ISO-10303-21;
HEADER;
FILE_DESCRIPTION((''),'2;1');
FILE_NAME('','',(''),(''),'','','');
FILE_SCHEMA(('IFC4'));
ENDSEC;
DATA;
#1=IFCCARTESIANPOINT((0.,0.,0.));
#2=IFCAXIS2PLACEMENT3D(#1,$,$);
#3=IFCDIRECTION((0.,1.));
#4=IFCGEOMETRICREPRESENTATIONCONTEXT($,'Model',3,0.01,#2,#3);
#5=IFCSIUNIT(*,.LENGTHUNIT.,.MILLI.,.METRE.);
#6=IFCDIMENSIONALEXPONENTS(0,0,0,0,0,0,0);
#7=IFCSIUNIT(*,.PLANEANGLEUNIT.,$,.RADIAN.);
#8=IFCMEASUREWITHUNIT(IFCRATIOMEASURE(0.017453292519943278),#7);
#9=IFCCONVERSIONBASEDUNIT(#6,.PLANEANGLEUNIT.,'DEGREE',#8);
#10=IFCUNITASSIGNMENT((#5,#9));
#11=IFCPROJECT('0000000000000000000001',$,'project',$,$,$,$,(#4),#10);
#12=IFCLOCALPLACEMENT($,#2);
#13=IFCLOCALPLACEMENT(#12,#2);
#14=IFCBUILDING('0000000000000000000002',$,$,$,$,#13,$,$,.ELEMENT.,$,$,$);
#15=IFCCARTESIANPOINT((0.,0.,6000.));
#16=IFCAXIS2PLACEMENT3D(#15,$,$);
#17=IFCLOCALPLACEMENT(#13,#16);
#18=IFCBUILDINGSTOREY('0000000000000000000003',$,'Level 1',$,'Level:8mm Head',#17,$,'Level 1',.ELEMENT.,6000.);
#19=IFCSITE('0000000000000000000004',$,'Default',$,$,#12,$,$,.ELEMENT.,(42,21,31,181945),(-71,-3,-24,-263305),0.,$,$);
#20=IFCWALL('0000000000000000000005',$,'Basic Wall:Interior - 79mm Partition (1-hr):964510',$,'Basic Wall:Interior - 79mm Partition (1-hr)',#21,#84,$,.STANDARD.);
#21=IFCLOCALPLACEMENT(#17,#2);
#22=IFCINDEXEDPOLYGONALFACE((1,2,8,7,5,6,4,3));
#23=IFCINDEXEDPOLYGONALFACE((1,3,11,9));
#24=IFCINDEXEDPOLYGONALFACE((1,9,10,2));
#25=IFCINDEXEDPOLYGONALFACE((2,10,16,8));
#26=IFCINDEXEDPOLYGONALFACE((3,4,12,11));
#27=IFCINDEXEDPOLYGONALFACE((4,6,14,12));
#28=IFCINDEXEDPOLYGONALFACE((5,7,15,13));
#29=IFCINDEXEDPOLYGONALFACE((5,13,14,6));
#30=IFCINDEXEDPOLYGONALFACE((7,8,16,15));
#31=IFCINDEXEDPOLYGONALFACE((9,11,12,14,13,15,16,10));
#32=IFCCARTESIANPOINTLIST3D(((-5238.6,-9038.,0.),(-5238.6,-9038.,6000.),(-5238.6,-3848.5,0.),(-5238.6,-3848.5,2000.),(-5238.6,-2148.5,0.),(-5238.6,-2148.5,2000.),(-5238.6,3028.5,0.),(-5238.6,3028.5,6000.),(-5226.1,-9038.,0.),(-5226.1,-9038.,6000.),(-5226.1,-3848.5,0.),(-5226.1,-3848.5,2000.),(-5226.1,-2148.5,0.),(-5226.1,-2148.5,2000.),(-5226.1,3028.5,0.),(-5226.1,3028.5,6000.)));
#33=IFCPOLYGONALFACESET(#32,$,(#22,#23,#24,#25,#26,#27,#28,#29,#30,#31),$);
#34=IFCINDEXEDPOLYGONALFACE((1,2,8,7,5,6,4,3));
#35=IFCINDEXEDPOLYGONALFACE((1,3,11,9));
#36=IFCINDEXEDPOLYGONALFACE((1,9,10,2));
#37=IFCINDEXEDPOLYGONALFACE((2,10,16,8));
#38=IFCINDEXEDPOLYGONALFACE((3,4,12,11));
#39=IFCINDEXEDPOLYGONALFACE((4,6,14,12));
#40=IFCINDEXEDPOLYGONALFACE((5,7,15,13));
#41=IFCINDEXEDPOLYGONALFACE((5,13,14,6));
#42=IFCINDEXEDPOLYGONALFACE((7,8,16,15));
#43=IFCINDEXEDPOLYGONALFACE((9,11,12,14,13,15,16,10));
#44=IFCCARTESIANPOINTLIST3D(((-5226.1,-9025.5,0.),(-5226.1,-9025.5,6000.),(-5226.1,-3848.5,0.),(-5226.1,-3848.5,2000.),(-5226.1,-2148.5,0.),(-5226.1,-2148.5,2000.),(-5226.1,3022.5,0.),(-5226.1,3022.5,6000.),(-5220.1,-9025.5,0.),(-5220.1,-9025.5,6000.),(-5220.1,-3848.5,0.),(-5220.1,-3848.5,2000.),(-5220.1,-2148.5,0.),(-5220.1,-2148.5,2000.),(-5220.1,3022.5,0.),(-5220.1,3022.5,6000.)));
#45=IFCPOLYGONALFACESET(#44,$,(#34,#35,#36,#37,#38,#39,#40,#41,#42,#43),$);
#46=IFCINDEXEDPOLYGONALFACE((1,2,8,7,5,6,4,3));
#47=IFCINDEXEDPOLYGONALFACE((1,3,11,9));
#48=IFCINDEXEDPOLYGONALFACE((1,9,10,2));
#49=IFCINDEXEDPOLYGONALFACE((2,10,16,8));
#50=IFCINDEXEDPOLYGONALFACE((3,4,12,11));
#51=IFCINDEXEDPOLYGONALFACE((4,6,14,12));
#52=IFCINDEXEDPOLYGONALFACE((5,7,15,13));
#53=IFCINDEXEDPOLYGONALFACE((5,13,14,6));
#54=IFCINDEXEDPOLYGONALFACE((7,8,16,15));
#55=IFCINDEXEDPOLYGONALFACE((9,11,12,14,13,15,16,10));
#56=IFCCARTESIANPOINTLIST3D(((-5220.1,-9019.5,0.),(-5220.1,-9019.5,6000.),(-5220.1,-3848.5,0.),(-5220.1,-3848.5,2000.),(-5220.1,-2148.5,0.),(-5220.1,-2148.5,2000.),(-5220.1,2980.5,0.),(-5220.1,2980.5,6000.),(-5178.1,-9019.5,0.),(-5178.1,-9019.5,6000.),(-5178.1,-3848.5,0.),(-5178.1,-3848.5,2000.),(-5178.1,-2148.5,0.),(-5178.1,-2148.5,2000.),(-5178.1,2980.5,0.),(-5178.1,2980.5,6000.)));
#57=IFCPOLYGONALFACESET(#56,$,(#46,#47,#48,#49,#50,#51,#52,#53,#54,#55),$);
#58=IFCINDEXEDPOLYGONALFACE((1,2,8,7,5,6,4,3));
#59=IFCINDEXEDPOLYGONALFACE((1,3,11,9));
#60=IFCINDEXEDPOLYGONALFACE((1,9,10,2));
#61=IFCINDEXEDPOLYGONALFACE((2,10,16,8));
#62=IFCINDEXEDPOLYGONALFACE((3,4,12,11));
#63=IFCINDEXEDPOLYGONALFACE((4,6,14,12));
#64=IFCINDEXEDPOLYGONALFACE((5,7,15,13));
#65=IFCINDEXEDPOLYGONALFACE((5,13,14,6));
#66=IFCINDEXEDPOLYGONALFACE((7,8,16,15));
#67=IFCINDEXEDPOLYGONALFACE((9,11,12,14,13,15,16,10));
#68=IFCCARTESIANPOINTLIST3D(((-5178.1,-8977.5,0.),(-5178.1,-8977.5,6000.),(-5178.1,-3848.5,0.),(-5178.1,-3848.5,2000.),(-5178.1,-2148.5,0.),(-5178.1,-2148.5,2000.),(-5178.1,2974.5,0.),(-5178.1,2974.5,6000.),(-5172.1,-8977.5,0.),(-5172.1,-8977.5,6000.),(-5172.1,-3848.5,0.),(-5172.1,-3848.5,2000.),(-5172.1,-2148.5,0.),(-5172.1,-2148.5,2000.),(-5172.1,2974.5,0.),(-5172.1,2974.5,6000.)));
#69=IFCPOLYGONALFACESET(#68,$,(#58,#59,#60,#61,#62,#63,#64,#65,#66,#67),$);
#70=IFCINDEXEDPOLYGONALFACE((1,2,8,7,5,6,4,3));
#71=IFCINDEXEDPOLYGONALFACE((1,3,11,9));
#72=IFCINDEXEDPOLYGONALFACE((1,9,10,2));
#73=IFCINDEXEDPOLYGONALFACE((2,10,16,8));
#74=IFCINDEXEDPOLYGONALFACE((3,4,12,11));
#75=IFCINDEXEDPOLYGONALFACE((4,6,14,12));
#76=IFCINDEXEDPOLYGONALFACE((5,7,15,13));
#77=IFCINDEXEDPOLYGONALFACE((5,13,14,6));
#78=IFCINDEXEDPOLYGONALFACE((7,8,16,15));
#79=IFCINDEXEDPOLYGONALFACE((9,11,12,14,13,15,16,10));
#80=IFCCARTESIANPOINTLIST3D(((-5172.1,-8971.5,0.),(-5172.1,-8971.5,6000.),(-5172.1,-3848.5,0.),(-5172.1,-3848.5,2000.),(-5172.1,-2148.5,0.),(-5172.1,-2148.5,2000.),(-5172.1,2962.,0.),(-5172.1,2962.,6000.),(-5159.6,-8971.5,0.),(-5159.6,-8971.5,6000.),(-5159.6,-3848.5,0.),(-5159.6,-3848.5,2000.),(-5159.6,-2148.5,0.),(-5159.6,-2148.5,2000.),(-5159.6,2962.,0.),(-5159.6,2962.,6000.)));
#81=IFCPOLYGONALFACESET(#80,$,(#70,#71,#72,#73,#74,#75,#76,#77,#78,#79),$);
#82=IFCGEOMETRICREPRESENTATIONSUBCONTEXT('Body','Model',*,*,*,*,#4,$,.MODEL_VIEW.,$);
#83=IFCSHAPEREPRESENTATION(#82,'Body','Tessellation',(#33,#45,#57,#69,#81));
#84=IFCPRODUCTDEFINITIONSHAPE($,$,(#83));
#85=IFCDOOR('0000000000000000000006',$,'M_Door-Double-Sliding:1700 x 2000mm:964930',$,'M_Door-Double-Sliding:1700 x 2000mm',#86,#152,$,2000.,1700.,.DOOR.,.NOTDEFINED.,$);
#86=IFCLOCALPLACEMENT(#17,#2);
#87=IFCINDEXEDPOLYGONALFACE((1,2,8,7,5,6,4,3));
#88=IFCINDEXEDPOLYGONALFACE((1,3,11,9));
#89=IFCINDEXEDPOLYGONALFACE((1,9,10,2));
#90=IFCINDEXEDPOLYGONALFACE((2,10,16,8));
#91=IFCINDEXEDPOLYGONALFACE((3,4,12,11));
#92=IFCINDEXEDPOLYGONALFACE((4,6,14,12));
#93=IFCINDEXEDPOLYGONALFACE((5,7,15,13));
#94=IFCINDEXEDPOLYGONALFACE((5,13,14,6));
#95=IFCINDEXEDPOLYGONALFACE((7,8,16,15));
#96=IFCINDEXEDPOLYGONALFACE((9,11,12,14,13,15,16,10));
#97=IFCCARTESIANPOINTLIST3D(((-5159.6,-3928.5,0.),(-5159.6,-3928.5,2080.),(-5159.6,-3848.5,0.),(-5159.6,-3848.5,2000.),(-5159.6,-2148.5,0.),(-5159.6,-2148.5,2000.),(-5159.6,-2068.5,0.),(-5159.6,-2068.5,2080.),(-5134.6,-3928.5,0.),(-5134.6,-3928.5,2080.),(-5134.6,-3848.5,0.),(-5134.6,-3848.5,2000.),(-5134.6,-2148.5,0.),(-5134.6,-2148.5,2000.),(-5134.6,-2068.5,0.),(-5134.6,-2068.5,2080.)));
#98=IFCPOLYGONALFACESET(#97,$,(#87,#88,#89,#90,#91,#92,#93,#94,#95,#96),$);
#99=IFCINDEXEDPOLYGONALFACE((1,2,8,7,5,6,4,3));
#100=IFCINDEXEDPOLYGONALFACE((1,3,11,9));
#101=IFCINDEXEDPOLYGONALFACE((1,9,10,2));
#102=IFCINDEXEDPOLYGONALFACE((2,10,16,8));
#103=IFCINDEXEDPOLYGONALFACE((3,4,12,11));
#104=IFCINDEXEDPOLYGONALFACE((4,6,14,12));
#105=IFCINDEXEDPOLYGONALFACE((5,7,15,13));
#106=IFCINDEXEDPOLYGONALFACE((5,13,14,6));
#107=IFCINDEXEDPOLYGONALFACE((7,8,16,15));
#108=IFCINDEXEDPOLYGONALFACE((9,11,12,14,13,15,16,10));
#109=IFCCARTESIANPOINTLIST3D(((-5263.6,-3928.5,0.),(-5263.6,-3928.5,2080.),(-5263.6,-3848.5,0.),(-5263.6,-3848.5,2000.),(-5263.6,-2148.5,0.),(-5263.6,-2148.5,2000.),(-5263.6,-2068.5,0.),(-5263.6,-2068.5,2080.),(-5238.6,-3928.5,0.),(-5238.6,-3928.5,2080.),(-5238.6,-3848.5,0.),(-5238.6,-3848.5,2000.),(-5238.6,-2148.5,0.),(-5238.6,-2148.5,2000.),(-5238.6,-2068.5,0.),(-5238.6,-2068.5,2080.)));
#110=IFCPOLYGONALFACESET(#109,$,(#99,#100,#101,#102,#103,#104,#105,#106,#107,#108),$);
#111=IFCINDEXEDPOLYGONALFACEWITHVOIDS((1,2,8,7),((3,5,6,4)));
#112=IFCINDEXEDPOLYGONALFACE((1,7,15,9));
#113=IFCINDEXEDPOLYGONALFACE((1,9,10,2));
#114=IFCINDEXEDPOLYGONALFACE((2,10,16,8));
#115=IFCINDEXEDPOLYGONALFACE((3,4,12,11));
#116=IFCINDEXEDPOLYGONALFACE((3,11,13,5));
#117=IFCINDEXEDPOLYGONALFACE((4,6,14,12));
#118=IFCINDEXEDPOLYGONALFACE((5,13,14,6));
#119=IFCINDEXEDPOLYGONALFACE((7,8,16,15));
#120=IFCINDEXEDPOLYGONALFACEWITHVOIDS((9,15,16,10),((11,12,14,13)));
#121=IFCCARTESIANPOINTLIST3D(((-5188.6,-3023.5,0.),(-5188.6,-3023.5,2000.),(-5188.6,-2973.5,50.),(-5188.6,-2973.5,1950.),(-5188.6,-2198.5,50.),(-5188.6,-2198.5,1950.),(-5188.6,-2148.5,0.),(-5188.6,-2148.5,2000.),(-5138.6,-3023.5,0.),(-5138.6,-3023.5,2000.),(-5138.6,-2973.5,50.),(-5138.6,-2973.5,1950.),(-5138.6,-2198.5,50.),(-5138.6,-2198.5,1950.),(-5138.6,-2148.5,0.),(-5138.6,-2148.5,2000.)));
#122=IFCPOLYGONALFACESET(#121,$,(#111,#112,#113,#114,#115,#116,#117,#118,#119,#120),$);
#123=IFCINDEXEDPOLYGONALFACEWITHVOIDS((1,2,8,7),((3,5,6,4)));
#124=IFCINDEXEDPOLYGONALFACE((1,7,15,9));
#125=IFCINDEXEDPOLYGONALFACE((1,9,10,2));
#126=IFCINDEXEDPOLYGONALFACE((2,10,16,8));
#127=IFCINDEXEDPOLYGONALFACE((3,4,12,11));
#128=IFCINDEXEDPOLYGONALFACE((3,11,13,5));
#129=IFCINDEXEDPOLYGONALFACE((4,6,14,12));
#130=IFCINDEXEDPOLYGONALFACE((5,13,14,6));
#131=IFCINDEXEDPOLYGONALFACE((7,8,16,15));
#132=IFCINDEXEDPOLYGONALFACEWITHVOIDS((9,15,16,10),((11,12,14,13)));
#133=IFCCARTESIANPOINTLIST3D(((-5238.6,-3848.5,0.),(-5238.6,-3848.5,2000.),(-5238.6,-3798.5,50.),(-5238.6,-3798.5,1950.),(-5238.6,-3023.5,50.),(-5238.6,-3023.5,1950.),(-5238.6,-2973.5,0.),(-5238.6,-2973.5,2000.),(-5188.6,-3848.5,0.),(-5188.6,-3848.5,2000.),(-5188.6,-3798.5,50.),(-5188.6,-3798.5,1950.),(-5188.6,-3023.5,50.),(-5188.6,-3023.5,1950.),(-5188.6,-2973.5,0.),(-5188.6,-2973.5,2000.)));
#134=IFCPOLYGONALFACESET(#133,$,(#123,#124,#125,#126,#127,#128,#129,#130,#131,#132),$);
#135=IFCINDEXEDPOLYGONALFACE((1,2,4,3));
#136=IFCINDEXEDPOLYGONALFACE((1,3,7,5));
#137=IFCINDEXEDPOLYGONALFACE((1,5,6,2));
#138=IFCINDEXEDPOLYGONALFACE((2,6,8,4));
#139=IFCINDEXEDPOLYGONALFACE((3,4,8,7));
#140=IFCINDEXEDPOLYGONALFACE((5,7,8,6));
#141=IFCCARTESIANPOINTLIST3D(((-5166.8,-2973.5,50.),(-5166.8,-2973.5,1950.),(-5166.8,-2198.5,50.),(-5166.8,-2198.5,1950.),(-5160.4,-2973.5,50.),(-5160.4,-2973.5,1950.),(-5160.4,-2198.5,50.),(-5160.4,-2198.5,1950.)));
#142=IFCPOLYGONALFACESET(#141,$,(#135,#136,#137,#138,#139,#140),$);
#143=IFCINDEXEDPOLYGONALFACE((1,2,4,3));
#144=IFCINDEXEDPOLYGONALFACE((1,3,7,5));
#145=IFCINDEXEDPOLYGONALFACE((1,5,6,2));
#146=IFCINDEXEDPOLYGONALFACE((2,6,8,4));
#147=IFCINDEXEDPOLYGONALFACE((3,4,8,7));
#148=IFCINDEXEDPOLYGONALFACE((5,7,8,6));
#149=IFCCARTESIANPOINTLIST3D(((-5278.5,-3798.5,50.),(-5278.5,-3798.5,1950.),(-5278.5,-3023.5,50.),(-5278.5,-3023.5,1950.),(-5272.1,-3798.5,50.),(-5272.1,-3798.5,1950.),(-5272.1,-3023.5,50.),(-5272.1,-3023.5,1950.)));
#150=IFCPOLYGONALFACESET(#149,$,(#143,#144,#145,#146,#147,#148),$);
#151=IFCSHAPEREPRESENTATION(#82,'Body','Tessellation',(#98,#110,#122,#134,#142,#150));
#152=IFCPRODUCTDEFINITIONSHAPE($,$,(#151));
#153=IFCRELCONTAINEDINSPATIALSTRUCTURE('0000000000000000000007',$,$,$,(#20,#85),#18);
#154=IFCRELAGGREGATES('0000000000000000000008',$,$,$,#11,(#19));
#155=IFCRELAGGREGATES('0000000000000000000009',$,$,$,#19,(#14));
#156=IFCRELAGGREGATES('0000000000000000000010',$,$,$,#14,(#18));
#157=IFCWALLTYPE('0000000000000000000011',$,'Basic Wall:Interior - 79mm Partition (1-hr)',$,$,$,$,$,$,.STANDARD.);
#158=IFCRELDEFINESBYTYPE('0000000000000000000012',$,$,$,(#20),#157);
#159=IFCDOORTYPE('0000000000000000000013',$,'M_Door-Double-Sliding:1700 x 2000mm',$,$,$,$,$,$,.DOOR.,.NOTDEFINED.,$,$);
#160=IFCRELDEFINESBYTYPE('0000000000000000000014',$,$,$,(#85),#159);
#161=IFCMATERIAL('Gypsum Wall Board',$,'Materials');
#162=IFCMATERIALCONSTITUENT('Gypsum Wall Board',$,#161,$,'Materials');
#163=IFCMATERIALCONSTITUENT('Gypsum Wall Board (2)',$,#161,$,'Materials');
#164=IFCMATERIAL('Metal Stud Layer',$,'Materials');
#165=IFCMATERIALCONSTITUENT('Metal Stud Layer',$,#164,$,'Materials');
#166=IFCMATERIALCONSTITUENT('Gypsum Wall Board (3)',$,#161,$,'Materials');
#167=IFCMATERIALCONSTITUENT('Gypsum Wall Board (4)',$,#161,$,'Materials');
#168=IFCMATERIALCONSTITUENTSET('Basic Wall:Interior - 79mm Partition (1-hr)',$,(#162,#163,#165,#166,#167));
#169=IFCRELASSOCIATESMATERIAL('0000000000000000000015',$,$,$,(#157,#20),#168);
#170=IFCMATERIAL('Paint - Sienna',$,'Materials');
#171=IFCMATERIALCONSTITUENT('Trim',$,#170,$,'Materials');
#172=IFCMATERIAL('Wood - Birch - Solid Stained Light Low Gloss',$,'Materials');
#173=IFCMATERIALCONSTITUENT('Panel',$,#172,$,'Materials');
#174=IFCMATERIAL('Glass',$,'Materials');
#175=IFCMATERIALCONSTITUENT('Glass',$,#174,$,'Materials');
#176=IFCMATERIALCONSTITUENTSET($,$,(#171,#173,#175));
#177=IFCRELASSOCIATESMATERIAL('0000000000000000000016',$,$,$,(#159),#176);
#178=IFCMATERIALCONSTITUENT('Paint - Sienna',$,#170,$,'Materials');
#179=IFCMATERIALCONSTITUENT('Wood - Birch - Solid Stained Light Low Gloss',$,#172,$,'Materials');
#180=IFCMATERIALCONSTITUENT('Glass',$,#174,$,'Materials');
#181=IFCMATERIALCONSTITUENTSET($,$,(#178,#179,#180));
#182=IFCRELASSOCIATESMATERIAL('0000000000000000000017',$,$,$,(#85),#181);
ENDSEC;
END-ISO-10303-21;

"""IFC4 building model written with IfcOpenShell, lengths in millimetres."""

from ifc_helpers import new_model, entity, si_unit, converted_unit, direction, frame, origin, place, context, subcontext, project, spatial, indexed_curve, outline, extrude, source, transform, mapped, material, constituent, constituent_set, type_object, type_shapes, element, fill, save


model = new_model("IFC4")

# Units and contexts
model_context = context("Model", 3, precision=0.01, world=origin(), true_north=direction((0.0, 1.0)))
body_context = subcontext(model_context, "Body", "Model", "MODEL_VIEW")
ifc_project = project(units=[si_unit("LENGTHUNIT", "METRE", prefix="MILLI"), converted_unit("PLANEANGLEUNIT", "DEGREE", entity("IfcRatioMeasure", 0.017453292519943278), si_unit("PLANEANGLEUNIT", "RADIAN"), dimensions=[0, 0, 0, 0, 0, 0, 0])], contexts=[model_context])

# Site, building, storey
site_placement = place(None, origin())
site = spatial("IfcSite", under=ifc_project, at=site_placement, Name="Default", CompositionType="ELEMENT", RefLatitude=(42, 21, 31, 181945), RefLongitude=(-71, -3, -24, -263305), RefElevation=0.0)
building_placement = place(site_placement, origin())
building = spatial("IfcBuilding", under=site, at=building_placement, CompositionType="ELEMENT")
storey_placement = place(building_placement, frame((0.0, 0.0, 6000.0)))
storey = spatial("IfcBuildingStorey", under=building, at=storey_placement, Name="Level 1", ObjectType="Level:8mm Head", LongName="Level 1", CompositionType="ELEMENT", Elevation=6000.0)

# Shared definitions
ifc_material_1 = material(Name="Gypsum Wall Board", Category="Materials")
ifc_constituent_1 = constituent(ifc_material_1, Name="Gypsum Wall Board", Category="Materials")
ifc_constituent_2 = constituent(ifc_material_1, Name="Gypsum Wall Board (2)", Category="Materials")
ifc_material_2 = material(Name="Metal Stud Layer", Category="Materials")
ifc_constituent_3 = constituent(ifc_material_2, Name="Metal Stud Layer", Category="Materials")
ifc_constituent_4 = constituent(ifc_material_1, Name="Gypsum Wall Board (3)", Category="Materials")
ifc_constituent_5 = constituent(ifc_material_1, Name="Gypsum Wall Board (4)", Category="Materials")
ifc_constituent_set_1 = constituent_set(constituents=[ifc_constituent_1, ifc_constituent_2, ifc_constituent_3, ifc_constituent_4, ifc_constituent_5], Name="Basic Wall:Interior - 79mm Partition (1-hr)")
wall_type = type_object("IfcWallType", Name="Basic Wall:Interior - 79mm Partition (1-hr)", PredefinedType="STANDARD", material=ifc_constituent_set_1)

# Wall, opening, door
ifc_material_3 = material(Name="Paint - Sienna", Category="Materials")
ifc_material_4 = material(Name="Wood - Birch - Solid Stained Light Low Gloss", Category="Materials")
ifc_material_5 = material(Name="Glass", Category="Materials")
ifc_constituent_6 = constituent(ifc_material_3, Name="Trim", Category="Materials")
ifc_constituent_7 = constituent(ifc_material_4, Name="Panel", Category="Materials")
ifc_constituent_8 = constituent(ifc_material_5, Name="Glass", Category="Materials")
ifc_constituent_set_2 = constituent_set(constituents=[ifc_constituent_6, ifc_constituent_7, ifc_constituent_8])
door_type = type_object("IfcDoorType", Name="M_Door-Double-Sliding:1700 x 2000mm", OperationType="NOTDEFINED", PredefinedType="DOOR", material=ifc_constituent_set_2)
shared_shape_1 = source(origin(), body_context, "Body", "SweptSolid", [
    extrude(outline(indexed_curve([(-1020.0, -930.0), (1060.0, -930.0), (1060.0, 930.0), (-1020.0, 930.0), (-1020.0, 850.0), (980.0, 850.0), (980.0, -850.0), (-1020.0, -850.0), (-1020.0, -930.0)], self_intersect=False)), frame((850.0, -25.0, 1020.0), z_axis=(0.0, 1.0, 0.0), x_axis=(0.0, 0.0, 1.0)), (0.0, 0.0, 1.0), 25.0),
    extrude(outline(indexed_curve([(-930.0, -1020.0), (-850.0, -1020.0), (-850.0, 980.0), (850.0, 980.0), (850.0, -1020.0), (930.0, -1020.0), (930.0, 1060.0), (-930.0, 1060.0), (-930.0, -1020.0)], self_intersect=False)), frame((850.0, 79.0, 1020.0), z_axis=(0.0, 1.0, 0.0), x_axis=(-1.0, 0.0, 0.0)), (0.0, 0.0, 1.0), 25.0),
    extrude(outline(indexed_curve([(-437.5, -1000.0), (437.5, -1000.0), (437.5, 1000.0), (-437.5, 1000.0), (-437.5, -1000.0)], self_intersect=False), holes=[indexed_curve([(-387.5, -950.0), (-387.5, 950.0), (387.5, 950.0), (387.5, -950.0), (-387.5, -950.0)], self_intersect=False)]), frame((1262.5, -21.0, 1000.0), z_axis=(0.0, 1.0, 0.0), x_axis=(1.0, 0.0, 0.0)), (0.0, 0.0, 1.0), 50.0),
    extrude(outline(indexed_curve([(-1000.0, -437.5), (1000.0, -437.5), (1000.0, 437.5), (-1000.0, 437.5), (-1000.0, -437.5)], self_intersect=False), holes=[indexed_curve([(-950.0, -387.5), (-950.0, 387.5), (950.0, 387.5), (950.0, -387.5), (-950.0, -387.5)], self_intersect=False)]), frame((437.5, 29.0, 1000.0), z_axis=(0.0, 1.0, 0.0), x_axis=(0.0, 0.0, -1.0)), (0.0, 0.0, 1.0), 50.0),
    extrude(outline(indexed_curve([(-3.2, -387.5), (3.2, -387.5), (3.2, 387.5), (-3.2, 387.5), (-3.2, -387.5)], self_intersect=False)), frame((1262.5, 4.0, 50.0), z_axis=(0.0, 0.0, 1.0), x_axis=(0.0, -1.0, 0.0)), (0.0, 0.0, 1.0), 1900.0),
    extrude(outline(indexed_curve([(-3.2, -387.5), (3.2, -387.5), (3.2, 387.5), (-3.2, 387.5), (-3.2, -387.5)], self_intersect=False)), frame((437.5, 115.7, 50.0), z_axis=(0.0, 0.0, 1.0), x_axis=(0.0, 1.0, 0.0)), (0.0, 0.0, 1.0), 1900.0),
])
type_shapes(door_type, [shared_shape_1])
wall_1_placement = place(storey_placement, frame((-5199.1, 2962.0, 0.0), z_axis=(0.0, 0.0, 1.0), x_axis=(0.0, -1.0, 0.0)))
wall_1 = element("IfcWall", 1, at=wall_1_placement, inside=storey, type_object=wall_type, material=ifc_constituent_set_1, Name="Basic Wall:Interior - 79mm Partition (1-hr):964510", ObjectType="Basic Wall:Interior - 79mm Partition (1-hr)", PredefinedType="STANDARD", context=body_context, shape_type="SweptSolid", body=[
    extrude(outline(indexed_curve([(-2000.0, -6030.1), (4000.0, -6030.1), (4000.0, 6036.4), (-2000.0, 6036.4), (-2000.0, 846.9), (0.0, 846.9), (0.0, -853.1), (-2000.0, -853.1), (-2000.0, -6030.1)], self_intersect=False)), frame((5963.6, -39.5, 2000.0), z_axis=(0.0, 1.0, 0.0), x_axis=(0.0, 0.0, 1.0)), (0.0, 0.0, 1.0), 12.5),
    extrude(outline(indexed_curve([(-2000.0, -6022.5), (4000.0, -6022.5), (4000.0, 6025.5), (-2000.0, 6025.5), (-2000.0, 848.5), (0.0, 848.5), (0.0, -851.5), (-2000.0, -851.5), (-2000.0, -6022.5)], self_intersect=False)), frame((5962.0, -27.0, 2000.0), z_axis=(0.0, 1.0, 0.0), x_axis=(0.0, 0.0, 1.0)), (0.0, 0.0, 1.0), 6.0),
    extrude(outline(indexed_curve([(-2000.0, -5989.5), (4000.0, -5989.5), (4000.0, 6010.5), (-2000.0, 6010.5), (-2000.0, 839.5), (0.0, 839.5), (0.0, -860.5), (-2000.0, -860.5), (-2000.0, -5989.5)], self_intersect=False)), frame((5971.0, -21.0, 2000.0), z_axis=(0.0, 1.0, 0.0), x_axis=(0.0, 0.0, 1.0)), (0.0, 0.0, 1.0), 42.0),
    extrude(outline(indexed_curve([(-2000.0, -5974.5), (4000.0, -5974.5), (4000.0, 5977.5), (-2000.0, 5977.5), (-2000.0, 848.5), (0.0, 848.5), (0.0, -851.5), (-2000.0, -851.5), (-2000.0, -5974.5)], self_intersect=False)), frame((5962.0, 21.0, 2000.0), z_axis=(0.0, 1.0, 0.0), x_axis=(0.0, 0.0, 1.0)), (0.0, 0.0, 1.0), 6.0),
    extrude(outline(indexed_curve([(-2000.0, -5963.6), (4000.0, -5963.6), (4000.0, 5969.9), (-2000.0, 5969.9), (-2000.0, 846.9), (0.0, 846.9), (0.0, -853.1), (-2000.0, -853.1), (-2000.0, -5963.6)], self_intersect=False)), frame((5963.6, 27.0, 2000.0), z_axis=(0.0, 1.0, 0.0), x_axis=(0.0, 0.0, 1.0)), (0.0, 0.0, 1.0), 12.5),
])
opening_1_placement = place(wall_1_placement, frame((6810.5, 39.5, 0.0)))
opening_1 = element("IfcOpeningElement", 2, at=opening_1_placement, cuts=wall_1, PredefinedType="OPENING", context=body_context, shape_type="SweptSolid", body=[
    extrude(outline(indexed_curve([(2000.0, 0.0), (2000.0, 1700.0), (0.0, 1700.0), (0.0, 0.0), (2000.0, 0.0)], self_intersect=False)), frame((0.0, 0.0, 0.0), z_axis=(0.0, -1.0, 0.0), x_axis=(0.0, 0.0, 1.0)), (0.0, 0.0, 1.0), 79.0),
])
ifc_constituent_9 = constituent(ifc_material_3, Name="Paint - Sienna", Category="Materials")
ifc_constituent_10 = constituent(ifc_material_4, Name="Wood - Birch - Solid Stained Light Low Gloss", Category="Materials")
ifc_constituent_11 = constituent(ifc_material_5, Name="Glass", Category="Materials")
ifc_constituent_set_3 = constituent_set(constituents=[ifc_constituent_9, ifc_constituent_10, ifc_constituent_11])
door_1_placement = place(opening_1_placement, frame((0.0, 0.0, 0.0), z_axis=(0.0, 0.0, 1.0), x_axis=(-1.0, 0.0, 0.0)))
door_1 = element("IfcDoor", 3, at=door_1_placement, inside=storey, type_object=door_type, material=ifc_constituent_set_3, Name="M_Door-Double-Sliding:1700 x 2000mm:964930", ObjectType="M_Door-Double-Sliding:1700 x 2000mm", OperationType="NOTDEFINED", OverallHeight=2000.0, OverallWidth=1700.0, PredefinedType="DOOR", context=body_context, shape_type="MappedRepresentation", body=[
    mapped(shared_shape_1, transform((0.0, 0.0, 0.0), scale=1.0)),
])
fill(opening_1, door_1)

save(model, "model.ifc")
